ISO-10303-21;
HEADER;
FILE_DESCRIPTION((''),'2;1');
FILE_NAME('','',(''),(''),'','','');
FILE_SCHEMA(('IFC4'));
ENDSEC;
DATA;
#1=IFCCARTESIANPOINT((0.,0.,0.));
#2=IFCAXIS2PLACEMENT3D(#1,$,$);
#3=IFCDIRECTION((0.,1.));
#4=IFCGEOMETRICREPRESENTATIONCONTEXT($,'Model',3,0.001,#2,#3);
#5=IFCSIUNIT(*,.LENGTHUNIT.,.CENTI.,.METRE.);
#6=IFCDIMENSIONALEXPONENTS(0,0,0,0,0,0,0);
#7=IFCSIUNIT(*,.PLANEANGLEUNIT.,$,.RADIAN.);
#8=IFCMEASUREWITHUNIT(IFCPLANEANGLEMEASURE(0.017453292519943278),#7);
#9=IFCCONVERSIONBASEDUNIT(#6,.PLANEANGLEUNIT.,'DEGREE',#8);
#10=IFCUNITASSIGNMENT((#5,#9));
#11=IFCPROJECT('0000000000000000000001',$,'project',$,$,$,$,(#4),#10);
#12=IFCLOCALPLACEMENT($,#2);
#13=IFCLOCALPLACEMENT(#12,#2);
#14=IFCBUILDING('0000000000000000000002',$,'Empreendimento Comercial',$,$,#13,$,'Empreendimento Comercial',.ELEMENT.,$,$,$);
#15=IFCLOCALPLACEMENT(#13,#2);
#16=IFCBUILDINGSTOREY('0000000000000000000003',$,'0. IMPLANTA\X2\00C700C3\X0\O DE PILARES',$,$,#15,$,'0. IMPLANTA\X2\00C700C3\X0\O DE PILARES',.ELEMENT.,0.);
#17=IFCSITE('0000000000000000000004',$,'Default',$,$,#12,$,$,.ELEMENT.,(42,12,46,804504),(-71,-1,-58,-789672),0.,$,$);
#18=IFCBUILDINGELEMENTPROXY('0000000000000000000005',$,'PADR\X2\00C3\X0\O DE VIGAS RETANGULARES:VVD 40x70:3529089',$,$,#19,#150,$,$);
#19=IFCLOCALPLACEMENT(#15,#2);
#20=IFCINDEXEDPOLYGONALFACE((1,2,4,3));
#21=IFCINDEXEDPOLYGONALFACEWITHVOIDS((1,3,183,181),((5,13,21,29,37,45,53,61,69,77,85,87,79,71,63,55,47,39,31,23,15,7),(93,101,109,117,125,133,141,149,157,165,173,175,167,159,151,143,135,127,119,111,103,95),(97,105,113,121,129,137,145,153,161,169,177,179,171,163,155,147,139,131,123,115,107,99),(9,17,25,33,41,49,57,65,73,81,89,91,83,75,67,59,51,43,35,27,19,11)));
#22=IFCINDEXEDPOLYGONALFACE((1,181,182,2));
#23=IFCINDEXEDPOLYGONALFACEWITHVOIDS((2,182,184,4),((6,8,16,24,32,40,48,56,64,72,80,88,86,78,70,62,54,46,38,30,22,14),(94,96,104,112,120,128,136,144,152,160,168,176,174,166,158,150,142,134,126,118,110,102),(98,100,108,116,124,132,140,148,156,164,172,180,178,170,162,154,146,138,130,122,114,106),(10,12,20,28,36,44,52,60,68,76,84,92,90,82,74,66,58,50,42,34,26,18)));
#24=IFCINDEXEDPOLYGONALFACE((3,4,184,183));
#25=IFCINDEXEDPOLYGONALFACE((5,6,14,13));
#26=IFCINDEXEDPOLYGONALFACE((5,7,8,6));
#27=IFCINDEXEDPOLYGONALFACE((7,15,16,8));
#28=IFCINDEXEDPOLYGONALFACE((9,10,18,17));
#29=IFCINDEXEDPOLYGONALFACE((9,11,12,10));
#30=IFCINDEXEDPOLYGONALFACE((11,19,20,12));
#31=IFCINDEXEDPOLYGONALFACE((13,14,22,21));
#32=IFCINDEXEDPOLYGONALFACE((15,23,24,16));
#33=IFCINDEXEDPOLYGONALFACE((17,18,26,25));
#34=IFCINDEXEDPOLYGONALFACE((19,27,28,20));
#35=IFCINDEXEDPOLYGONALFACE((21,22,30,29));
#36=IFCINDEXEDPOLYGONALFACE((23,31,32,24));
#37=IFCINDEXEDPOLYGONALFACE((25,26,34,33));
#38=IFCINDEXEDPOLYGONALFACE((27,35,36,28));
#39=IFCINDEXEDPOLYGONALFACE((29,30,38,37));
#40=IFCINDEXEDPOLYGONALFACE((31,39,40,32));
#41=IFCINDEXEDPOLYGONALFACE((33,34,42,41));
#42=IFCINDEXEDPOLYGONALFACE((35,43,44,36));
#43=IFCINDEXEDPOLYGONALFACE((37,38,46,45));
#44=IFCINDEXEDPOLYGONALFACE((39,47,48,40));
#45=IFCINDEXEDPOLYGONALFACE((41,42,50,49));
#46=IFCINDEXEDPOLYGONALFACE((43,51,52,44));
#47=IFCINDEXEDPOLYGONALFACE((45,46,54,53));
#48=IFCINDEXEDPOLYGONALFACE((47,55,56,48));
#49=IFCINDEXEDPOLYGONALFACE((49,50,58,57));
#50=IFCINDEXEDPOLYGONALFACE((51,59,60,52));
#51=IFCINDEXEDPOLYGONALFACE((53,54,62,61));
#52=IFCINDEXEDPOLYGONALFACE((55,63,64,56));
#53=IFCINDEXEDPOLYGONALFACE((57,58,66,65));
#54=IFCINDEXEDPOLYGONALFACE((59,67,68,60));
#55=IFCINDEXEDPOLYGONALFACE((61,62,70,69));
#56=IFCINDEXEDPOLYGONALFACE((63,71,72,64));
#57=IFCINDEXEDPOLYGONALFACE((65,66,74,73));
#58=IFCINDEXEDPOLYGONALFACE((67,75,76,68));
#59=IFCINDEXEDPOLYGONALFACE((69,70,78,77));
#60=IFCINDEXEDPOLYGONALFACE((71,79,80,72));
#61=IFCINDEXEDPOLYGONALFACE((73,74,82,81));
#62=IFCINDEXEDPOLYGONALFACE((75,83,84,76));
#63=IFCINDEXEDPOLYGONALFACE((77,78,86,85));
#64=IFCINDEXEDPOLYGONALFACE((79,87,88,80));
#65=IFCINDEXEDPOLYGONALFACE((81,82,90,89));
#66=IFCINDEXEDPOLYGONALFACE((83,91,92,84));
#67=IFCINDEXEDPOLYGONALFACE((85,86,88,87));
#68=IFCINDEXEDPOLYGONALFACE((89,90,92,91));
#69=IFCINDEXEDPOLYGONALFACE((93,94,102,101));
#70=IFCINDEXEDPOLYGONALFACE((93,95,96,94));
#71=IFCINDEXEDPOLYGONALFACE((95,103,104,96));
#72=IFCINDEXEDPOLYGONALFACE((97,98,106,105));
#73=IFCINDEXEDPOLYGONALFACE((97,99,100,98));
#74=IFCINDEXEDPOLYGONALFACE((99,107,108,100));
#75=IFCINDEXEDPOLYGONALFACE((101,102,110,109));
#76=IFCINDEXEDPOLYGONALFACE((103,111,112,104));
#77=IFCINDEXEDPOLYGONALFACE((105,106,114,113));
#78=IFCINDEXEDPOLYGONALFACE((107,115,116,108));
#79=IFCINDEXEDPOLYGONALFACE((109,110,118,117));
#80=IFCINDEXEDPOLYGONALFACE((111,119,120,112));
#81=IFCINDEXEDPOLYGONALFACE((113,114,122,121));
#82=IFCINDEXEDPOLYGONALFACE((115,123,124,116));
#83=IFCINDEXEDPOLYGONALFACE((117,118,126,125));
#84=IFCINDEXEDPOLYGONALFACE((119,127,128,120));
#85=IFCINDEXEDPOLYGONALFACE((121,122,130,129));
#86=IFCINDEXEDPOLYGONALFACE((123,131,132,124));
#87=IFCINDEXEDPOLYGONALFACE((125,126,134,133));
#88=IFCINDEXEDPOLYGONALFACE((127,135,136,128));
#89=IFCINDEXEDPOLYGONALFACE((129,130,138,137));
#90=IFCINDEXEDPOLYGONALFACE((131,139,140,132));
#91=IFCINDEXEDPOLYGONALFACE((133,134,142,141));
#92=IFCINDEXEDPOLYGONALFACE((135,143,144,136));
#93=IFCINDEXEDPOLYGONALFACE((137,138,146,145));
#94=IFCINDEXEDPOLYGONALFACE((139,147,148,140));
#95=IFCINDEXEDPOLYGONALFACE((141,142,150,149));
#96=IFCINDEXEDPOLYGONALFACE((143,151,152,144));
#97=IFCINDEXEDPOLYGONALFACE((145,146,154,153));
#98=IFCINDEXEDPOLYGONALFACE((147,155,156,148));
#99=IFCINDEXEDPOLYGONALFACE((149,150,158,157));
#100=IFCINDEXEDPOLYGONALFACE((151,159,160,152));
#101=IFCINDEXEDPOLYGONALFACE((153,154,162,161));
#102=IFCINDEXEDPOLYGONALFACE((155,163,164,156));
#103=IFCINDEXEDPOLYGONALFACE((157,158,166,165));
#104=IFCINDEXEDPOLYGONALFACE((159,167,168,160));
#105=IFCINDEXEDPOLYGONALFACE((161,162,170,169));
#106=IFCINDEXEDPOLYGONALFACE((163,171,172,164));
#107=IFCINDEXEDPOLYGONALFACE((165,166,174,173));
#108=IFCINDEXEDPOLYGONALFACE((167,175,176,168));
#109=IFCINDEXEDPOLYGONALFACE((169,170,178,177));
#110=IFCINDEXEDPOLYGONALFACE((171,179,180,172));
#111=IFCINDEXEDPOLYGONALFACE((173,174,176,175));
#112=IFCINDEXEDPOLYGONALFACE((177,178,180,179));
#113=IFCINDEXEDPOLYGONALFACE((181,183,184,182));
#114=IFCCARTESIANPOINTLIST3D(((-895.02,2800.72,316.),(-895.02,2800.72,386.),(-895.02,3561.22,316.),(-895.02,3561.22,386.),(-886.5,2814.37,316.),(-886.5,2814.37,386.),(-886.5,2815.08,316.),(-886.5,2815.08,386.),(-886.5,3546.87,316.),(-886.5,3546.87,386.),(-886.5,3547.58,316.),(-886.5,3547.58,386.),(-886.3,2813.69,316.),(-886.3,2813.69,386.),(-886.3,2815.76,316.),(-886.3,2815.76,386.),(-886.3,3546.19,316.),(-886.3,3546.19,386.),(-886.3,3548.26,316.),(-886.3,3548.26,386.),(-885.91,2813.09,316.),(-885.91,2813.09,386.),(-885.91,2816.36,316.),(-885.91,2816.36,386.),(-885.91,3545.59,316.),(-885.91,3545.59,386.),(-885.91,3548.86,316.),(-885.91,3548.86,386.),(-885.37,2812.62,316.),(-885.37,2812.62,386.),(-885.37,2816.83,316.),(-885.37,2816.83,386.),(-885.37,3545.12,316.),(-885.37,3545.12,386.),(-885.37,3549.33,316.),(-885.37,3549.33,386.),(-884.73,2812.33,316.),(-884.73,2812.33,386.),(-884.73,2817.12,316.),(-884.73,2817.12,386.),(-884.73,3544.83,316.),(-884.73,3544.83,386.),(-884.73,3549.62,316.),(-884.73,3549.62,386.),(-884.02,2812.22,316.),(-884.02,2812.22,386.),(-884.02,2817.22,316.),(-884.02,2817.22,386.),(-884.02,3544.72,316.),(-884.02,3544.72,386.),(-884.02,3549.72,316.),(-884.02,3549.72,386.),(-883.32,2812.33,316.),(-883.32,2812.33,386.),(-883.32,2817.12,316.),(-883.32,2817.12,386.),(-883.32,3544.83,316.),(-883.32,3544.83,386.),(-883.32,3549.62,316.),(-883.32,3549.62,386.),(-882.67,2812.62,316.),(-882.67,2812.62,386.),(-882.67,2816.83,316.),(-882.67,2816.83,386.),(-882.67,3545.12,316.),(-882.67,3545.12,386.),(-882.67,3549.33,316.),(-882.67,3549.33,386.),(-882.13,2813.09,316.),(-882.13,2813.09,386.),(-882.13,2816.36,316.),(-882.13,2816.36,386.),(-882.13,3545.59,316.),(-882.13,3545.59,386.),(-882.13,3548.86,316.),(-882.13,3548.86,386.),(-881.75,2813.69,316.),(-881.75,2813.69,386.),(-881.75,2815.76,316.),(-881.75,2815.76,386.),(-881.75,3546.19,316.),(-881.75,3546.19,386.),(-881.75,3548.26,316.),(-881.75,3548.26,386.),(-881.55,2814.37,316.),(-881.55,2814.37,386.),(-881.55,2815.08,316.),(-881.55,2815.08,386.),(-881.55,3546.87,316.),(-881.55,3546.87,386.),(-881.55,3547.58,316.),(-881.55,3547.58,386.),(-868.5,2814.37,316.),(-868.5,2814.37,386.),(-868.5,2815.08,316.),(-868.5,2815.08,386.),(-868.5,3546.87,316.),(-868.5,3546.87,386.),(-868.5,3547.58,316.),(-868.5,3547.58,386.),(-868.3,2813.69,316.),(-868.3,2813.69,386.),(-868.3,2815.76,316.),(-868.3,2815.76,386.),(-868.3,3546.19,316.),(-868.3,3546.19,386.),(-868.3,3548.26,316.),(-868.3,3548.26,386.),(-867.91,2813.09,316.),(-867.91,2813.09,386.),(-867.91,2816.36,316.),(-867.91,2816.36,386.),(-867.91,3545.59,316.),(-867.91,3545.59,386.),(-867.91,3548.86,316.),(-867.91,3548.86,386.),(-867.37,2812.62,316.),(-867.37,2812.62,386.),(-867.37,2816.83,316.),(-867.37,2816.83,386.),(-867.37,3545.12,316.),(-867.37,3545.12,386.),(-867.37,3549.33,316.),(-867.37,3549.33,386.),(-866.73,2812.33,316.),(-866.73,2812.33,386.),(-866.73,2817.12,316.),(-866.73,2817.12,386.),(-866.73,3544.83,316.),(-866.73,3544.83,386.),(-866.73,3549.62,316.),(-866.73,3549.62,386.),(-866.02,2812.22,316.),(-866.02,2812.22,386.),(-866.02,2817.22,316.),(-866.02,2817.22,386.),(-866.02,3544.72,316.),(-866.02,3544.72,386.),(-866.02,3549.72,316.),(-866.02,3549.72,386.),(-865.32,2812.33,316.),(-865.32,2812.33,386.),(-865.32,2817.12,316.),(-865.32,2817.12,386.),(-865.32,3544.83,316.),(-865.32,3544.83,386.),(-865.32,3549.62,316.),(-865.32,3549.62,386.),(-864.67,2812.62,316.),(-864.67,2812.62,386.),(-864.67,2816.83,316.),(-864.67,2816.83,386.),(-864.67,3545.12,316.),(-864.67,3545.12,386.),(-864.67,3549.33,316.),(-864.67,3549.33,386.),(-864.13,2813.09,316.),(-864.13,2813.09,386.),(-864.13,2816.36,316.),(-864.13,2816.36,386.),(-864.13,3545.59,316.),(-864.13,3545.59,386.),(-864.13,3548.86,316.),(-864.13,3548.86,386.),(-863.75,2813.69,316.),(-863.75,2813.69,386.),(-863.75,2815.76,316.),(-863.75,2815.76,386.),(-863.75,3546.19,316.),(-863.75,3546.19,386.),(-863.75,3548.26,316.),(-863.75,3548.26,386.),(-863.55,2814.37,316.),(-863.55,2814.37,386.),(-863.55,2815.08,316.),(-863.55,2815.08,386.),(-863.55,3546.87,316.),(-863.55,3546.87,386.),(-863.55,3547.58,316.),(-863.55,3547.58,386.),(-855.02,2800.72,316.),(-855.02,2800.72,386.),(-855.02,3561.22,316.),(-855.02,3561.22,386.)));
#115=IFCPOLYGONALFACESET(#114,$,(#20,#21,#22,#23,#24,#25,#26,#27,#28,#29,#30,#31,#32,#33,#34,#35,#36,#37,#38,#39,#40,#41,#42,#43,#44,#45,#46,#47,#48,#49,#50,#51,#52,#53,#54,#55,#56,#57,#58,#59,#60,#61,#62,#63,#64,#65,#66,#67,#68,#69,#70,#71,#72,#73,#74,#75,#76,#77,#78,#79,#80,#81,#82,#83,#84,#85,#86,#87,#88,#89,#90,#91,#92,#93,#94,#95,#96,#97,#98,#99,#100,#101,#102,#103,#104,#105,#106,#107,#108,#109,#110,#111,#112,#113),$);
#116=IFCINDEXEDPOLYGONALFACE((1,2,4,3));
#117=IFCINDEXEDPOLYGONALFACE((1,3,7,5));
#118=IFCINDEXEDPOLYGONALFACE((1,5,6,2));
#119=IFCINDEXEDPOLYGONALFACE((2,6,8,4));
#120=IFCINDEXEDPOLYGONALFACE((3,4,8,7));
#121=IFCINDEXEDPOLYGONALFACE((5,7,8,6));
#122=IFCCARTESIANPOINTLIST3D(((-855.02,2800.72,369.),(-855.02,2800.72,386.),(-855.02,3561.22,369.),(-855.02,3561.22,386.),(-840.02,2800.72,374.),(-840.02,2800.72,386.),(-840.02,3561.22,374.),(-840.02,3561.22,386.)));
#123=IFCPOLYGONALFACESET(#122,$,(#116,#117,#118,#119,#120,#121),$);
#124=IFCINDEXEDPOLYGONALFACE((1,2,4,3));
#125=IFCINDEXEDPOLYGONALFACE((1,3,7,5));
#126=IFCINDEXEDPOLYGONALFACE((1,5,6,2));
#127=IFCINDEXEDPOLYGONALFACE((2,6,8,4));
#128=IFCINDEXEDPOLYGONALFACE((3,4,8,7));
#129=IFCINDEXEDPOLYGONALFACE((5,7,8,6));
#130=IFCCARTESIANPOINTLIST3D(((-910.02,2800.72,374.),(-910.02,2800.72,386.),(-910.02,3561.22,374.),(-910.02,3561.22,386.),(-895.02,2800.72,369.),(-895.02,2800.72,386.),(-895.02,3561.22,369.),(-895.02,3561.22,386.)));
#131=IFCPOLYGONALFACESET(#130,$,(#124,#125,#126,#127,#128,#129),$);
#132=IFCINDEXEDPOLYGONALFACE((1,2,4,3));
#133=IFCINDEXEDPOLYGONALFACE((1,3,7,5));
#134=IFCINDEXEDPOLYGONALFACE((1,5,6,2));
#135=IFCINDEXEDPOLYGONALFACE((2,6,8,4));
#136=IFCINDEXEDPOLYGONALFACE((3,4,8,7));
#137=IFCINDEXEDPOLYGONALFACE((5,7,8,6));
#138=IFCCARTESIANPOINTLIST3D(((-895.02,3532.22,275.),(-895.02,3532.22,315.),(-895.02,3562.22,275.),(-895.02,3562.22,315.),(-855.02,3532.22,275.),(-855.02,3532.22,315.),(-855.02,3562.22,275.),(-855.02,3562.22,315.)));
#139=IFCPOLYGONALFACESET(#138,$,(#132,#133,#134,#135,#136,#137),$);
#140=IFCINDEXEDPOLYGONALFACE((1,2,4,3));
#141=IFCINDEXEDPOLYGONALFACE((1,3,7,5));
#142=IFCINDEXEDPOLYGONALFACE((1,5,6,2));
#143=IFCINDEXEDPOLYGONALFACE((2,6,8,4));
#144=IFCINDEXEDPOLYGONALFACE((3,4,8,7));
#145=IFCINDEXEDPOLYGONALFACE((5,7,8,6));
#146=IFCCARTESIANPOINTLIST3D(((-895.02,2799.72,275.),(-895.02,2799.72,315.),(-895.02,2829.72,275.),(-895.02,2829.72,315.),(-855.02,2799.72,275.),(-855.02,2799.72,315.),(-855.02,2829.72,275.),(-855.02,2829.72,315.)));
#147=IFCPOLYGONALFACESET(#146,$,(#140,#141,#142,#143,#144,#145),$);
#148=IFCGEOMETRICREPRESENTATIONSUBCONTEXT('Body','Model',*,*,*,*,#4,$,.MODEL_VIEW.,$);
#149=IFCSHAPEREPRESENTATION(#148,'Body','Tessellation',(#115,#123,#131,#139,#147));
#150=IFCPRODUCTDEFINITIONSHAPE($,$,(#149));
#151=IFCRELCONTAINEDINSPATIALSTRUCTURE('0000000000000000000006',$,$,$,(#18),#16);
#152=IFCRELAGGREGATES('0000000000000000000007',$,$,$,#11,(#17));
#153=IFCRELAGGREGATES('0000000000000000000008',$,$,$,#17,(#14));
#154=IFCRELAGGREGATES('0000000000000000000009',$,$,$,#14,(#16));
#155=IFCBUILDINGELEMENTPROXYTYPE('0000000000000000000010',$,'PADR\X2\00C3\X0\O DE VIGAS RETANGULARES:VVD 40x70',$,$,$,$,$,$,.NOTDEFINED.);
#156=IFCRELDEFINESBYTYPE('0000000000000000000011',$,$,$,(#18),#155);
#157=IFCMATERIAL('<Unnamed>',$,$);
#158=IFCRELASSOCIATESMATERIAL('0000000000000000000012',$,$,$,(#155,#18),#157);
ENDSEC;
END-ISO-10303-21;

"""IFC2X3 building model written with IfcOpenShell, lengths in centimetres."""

from ifc_helpers import new_model, entity, si_unit, converted_unit, direction, frame, frame_2d, origin, origin_2d_with_axis, place, context, subcontext, project, spatial, polyline, circle_curve, parameter, trimmed, segment, composite_curve, rectangle, outline, extrude, source, transform, mapped, material, type_object, type_shapes, element, save


model = new_model("IFC2X3")

# Units and contexts
model_context = context("Model", 3, precision=0.001, world=origin(), true_north=direction((0.0, 1.0)))
body_context = subcontext(model_context, "Body", "Model", "MODEL_VIEW")
ifc_project = project(units=[si_unit("LENGTHUNIT", "METRE", prefix="CENTI"), converted_unit("PLANEANGLEUNIT", "DEGREE", entity("IfcPlaneAngleMeasure", 0.017453292519943278), si_unit("PLANEANGLEUNIT", "RADIAN"), dimensions=[0, 0, 0, 0, 0, 0, 0])], contexts=[model_context])

# Site, building, storey
site_placement = place(None, origin())
site = spatial("IfcSite", under=ifc_project, at=site_placement, Name="Default", CompositionType="ELEMENT", RefLatitude=(42, 12, 46, 804504), RefLongitude=(-71, -1, -58, -789672), RefElevation=0.0)
building_placement = place(site_placement, origin())
building = spatial("IfcBuilding", under=site, at=building_placement, Name="Empreendimento Comercial", LongName="Empreendimento Comercial", CompositionType="ELEMENT")
storey_placement = place(building_placement, origin())
storey = spatial("IfcBuildingStorey", under=building, at=storey_placement, Name="0. IMPLANTAÇÃO DE PILARES", LongName="0. IMPLANTAÇÃO DE PILARES", CompositionType="ELEMENT", Elevation=0.0)

# Building element proxy
ifc_material_1 = material(Name="<Unnamed>")
building_element_proxy_type_1 = type_object("IfcBuildingElementProxyType", Name="PADRÃO DE VIGAS RETANGULARES:VVD 40x70", PredefinedType="NOTDEFINED", material=ifc_material_1)
shared_shape_1 = source(origin(), body_context, "Body", "SweptSolid", [
    extrude(outline(polyline([(-20.0, -380.25), (20.0, -380.25), (20.0, 380.25), (-20.0, 380.25), (-20.0, -380.25)]), holes=[composite_curve([segment(trimmed(circle_curve(frame_2d((-9.0, -366.25), x_axis=(0.0, -1.0)), 2.5), [parameter(0.0)], [parameter(180.0)], True, "PARAMETER"), False, "CONTINUOUS"), segment(trimmed(circle_curve(frame_2d((-9.0, -366.25), x_axis=(0.0, -1.0)), 2.5), [parameter(180.0)], [parameter(0.0)], True, "PARAMETER"), False, "CONTINUOUS")], self_intersect=False), composite_curve([segment(trimmed(circle_curve(frame_2d((9.0, -366.25), x_axis=(0.0, -1.0)), 2.5), [parameter(0.0)], [parameter(180.0)], True, "PARAMETER"), False, "CONTINUOUS"), segment(trimmed(circle_curve(frame_2d((9.0, -366.25), x_axis=(0.0, -1.0)), 2.5), [parameter(180.0)], [parameter(0.0)], True, "PARAMETER"), False, "CONTINUOUS")], self_intersect=False), composite_curve([segment(trimmed(circle_curve(frame_2d((9.0, 366.25), x_axis=(0.0, -1.0)), 2.5), [parameter(0.0)], [parameter(180.0)], True, "PARAMETER"), False, "CONTINUOUS"), segment(trimmed(circle_curve(frame_2d((9.0, 366.25), x_axis=(0.0, -1.0)), 2.5), [parameter(180.0)], [parameter(0.0)], True, "PARAMETER"), False, "CONTINUOUS")], self_intersect=False), composite_curve([segment(trimmed(circle_curve(frame_2d((-9.0, 366.25), x_axis=(0.0, -1.0)), 2.5), [parameter(0.0)], [parameter(180.0)], True, "PARAMETER"), False, "CONTINUOUS"), segment(trimmed(circle_curve(frame_2d((-9.0, 366.25), x_axis=(0.0, -1.0)), 2.5), [parameter(180.0)], [parameter(0.0)], True, "PARAMETER"), False, "CONTINUOUS")], self_intersect=False)]), frame((-875.02, 3180.97, 316.0)), (0.0, 0.0, 1.0), 70.0),
    extrude(outline(polyline([(-7.25, -7.5), (4.75, -7.5), (9.75, 7.5), (-7.25, 7.5), (-7.25, -7.5)])), frame((-847.52, 2800.72, 378.75), z_axis=(0.0, 1.0, 0.0), x_axis=(0.0, 0.0, -1.0)), (0.0, 0.0, 1.0), 760.5),
    extrude(outline(polyline([(-7.5, -7.25), (7.5, -7.25), (7.5, 9.75), (-7.5, 4.75), (-7.5, -7.25)])), frame((-902.52, 2800.72, 378.75), z_axis=(0.0, 1.0, 0.0), x_axis=(1.0, 0.0, 0.0)), (0.0, 0.0, 1.0), 760.5),
    extrude(rectangle(XDim=30.0, YDim=40.0, at=frame_2d((0.0, 0.0), x_axis=(1.0, 0.0))), frame((-875.02, 3547.22, 275.0), z_axis=(0.0, 0.0, 1.0), x_axis=(0.0, 1.0, 0.0)), (0.0, 0.0, 1.0), 40.0),
    extrude(rectangle(XDim=30.0, YDim=40.0, at=origin_2d_with_axis()), frame((-875.02, 2814.72, 275.0), z_axis=(0.0, 0.0, 1.0), x_axis=(0.0, 1.0, 0.0)), (0.0, 0.0, 1.0), 40.0),
])
type_shapes(building_element_proxy_type_1, [shared_shape_1])
proxy_1_placement = place(storey_placement, origin())
element("IfcBuildingElementProxy", 1, at=proxy_1_placement, inside=storey, type_object=building_element_proxy_type_1, material=ifc_material_1, Name="PADRÃO DE VIGAS RETANGULARES:VVD 40x70:3529089", context=body_context, shape_type="MappedRepresentation", body=[
    mapped(shared_shape_1, transform((0.0, 0.0, 0.0), scale=1.0)),
])

save(model, "model.ifc")
